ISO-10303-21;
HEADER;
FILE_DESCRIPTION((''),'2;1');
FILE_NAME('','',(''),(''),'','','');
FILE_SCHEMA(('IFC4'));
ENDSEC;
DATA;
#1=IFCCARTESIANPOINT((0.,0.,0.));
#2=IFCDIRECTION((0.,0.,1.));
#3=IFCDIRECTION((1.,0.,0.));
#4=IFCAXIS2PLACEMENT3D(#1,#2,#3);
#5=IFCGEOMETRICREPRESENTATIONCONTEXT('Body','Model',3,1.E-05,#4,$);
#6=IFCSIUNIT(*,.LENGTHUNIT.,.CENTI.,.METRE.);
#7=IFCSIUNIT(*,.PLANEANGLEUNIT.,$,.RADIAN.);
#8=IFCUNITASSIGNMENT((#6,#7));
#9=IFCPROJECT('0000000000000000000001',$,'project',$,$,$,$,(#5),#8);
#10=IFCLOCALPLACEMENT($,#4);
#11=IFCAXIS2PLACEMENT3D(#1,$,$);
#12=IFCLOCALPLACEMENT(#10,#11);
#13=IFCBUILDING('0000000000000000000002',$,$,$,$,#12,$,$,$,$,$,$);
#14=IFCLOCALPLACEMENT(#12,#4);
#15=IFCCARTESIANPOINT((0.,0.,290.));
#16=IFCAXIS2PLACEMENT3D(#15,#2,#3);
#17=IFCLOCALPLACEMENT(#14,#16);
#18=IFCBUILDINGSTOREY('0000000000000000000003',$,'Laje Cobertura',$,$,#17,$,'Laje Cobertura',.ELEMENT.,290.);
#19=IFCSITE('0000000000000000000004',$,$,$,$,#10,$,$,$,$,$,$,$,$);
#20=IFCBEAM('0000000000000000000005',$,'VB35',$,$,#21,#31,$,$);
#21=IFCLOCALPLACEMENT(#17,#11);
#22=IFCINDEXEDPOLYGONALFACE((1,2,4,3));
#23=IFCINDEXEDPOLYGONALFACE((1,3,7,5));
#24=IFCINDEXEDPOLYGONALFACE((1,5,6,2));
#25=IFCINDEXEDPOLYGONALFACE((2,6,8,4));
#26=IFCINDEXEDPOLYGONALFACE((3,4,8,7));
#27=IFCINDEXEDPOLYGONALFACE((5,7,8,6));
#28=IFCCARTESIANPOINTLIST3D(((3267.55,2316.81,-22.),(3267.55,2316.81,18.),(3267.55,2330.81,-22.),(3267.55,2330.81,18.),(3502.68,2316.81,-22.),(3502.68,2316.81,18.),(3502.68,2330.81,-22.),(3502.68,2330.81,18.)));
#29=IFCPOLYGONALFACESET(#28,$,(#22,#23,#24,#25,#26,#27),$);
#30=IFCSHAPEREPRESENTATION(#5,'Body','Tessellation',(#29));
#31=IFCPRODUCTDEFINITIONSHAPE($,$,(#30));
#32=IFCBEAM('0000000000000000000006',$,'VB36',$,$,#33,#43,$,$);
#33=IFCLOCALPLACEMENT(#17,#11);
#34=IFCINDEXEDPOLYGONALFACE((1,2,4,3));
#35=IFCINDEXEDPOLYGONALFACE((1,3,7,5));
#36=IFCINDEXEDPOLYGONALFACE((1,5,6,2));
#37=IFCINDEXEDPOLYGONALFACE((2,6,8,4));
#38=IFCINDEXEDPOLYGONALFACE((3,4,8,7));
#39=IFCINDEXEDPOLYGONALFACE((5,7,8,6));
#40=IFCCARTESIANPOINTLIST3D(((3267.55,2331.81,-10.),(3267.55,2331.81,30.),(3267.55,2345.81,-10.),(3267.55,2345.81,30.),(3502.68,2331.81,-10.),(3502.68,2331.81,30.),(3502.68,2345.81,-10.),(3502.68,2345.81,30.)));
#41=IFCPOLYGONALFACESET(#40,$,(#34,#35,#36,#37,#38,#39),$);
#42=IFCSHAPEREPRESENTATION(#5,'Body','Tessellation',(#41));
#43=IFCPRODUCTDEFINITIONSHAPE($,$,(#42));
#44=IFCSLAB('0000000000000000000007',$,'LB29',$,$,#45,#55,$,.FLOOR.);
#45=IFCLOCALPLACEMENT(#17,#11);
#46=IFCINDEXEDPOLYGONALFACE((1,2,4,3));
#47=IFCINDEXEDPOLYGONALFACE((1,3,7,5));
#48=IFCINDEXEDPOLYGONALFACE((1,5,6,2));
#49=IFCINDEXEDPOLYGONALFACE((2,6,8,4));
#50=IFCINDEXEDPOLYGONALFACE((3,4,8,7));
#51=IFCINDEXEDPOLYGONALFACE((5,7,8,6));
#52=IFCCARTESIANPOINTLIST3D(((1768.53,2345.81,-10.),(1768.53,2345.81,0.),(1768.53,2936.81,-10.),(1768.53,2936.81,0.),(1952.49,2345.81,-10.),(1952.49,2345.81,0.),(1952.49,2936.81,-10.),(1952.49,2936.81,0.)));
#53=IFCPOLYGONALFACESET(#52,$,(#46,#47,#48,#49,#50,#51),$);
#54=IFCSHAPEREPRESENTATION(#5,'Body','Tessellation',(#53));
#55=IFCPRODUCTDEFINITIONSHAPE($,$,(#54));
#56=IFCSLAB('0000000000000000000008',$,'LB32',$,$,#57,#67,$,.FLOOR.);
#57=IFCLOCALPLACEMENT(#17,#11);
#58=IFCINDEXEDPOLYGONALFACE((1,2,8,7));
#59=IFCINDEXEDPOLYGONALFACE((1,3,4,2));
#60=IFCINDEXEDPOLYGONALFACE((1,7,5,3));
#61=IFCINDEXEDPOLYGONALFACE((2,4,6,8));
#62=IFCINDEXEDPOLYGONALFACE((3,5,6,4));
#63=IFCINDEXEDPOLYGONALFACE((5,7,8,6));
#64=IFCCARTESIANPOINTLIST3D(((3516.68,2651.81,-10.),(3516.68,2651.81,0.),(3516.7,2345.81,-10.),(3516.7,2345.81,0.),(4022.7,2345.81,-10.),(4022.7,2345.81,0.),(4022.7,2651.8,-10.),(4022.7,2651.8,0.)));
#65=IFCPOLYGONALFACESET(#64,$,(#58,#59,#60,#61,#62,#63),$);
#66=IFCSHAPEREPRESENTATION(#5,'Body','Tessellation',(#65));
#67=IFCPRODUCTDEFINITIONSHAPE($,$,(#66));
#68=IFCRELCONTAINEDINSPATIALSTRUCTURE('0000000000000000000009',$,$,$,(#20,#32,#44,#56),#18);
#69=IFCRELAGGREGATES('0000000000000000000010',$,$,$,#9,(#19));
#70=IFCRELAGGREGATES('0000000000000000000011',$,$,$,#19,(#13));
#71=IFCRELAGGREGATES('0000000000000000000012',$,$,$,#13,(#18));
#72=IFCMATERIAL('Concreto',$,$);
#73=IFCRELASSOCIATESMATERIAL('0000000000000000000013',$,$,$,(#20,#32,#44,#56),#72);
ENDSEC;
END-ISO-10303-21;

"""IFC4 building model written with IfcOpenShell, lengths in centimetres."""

from ifc_helpers import new_model, si_unit, frame, origin, origin_with_axes, origin_2d_with_axis, place, context, project, spatial, polyline, rectangle, outline, extrude, material, element, save


model = new_model("IFC4")

# Units and contexts
model_context = context("Model", 3, precision=1e-05, world=origin_with_axes(), identifier="Body")
ifc_project = project(units=[si_unit("LENGTHUNIT", "METRE", prefix="CENTI"), si_unit("PLANEANGLEUNIT", "RADIAN")], contexts=[model_context])

# Site, building, storey
site_placement = place(None, origin_with_axes())
site = spatial("IfcSite", under=ifc_project, at=site_placement)
building_placement = place(site_placement, origin())
building = spatial("IfcBuilding", under=site, at=building_placement)
placement = place(building_placement, origin_with_axes())
storey_placement = place(placement, frame((0.0, 0.0, 290.0), z_axis=(0.0, 0.0, 1.0), x_axis=(1.0, 0.0, 0.0)))
storey = spatial("IfcBuildingStorey", under=building, at=storey_placement, Name="Laje Cobertura", LongName="Laje Cobertura", CompositionType="ELEMENT", Elevation=290.0)

# Shared definitions
ifc_material = material(Name="Concreto")

# Beams
for number, where, z_axis, x_axis, name in (
    (1, (3385.11, 2323.81, 18.0), (0.0, 0.0, 1.0), (1.0, 0.0, 0.0), "VB35"),
    (2, (3385.11, 2338.81, 30.0), (0.0, 0.0, 1.0), (1.0, 0.0, 0.0), "VB36"),
):
    element("IfcBeam", number, at=place(storey_placement, frame(where, z_axis=z_axis, x_axis=x_axis)), inside=storey, material=ifc_material, Name=name, context=model_context, shape_type="SolidModel", body=[
        extrude(rectangle(XDim=14.0, YDim=40.0, at=origin_2d_with_axis()), frame((-117.56, 0.0, -20.0), z_axis=(1.0, 0.0, 0.0), x_axis=(0.0, 1.0, 0.0)), (0.0, 0.0, 1.0), 235.13),
    ])

# Slabs
slab_1_placement = place(storey_placement, frame((1860.51, 2641.31, 0.0), z_axis=(0.0, 0.0, 1.0), x_axis=(1.0, 0.0, 0.0)))
element("IfcSlab", 3, at=slab_1_placement, inside=storey, material=ifc_material, Name="LB29", PredefinedType="FLOOR", context=model_context, shape_type="SolidModel", body=[
    extrude(outline(polyline([(91.98, -295.5), (91.98, 295.5), (-91.98, 295.5), (-91.98, -295.5), (91.98, -295.5), (91.98, -295.5)])), frame((0.0, 0.0, -10.0), z_axis=(0.0, 0.0, 1.0), x_axis=(1.0, 0.0, 0.0)), (0.0, 0.0, 1.0), 10.0),
])
slab_2_placement = place(storey_placement, frame((3769.69, 2498.81, 0.0), z_axis=(0.0, 0.0, 1.0), x_axis=(1.0, 0.0, 0.0)))
element("IfcSlab", 4, at=slab_2_placement, inside=storey, material=ifc_material, Name="LB32", PredefinedType="FLOOR", context=model_context, shape_type="SolidModel", body=[
    extrude(outline(polyline([(253.01, 152.99), (-253.01, 153.0), (-252.99, -153.0), (253.01, -153.0), (253.01, 152.99), (253.01, 152.99)])), frame((0.0, 0.0, -10.0), z_axis=(0.0, 0.0, 1.0), x_axis=(1.0, 0.0, 0.0)), (0.0, 0.0, 1.0), 10.0),
])

save(model, "model.ifc")
